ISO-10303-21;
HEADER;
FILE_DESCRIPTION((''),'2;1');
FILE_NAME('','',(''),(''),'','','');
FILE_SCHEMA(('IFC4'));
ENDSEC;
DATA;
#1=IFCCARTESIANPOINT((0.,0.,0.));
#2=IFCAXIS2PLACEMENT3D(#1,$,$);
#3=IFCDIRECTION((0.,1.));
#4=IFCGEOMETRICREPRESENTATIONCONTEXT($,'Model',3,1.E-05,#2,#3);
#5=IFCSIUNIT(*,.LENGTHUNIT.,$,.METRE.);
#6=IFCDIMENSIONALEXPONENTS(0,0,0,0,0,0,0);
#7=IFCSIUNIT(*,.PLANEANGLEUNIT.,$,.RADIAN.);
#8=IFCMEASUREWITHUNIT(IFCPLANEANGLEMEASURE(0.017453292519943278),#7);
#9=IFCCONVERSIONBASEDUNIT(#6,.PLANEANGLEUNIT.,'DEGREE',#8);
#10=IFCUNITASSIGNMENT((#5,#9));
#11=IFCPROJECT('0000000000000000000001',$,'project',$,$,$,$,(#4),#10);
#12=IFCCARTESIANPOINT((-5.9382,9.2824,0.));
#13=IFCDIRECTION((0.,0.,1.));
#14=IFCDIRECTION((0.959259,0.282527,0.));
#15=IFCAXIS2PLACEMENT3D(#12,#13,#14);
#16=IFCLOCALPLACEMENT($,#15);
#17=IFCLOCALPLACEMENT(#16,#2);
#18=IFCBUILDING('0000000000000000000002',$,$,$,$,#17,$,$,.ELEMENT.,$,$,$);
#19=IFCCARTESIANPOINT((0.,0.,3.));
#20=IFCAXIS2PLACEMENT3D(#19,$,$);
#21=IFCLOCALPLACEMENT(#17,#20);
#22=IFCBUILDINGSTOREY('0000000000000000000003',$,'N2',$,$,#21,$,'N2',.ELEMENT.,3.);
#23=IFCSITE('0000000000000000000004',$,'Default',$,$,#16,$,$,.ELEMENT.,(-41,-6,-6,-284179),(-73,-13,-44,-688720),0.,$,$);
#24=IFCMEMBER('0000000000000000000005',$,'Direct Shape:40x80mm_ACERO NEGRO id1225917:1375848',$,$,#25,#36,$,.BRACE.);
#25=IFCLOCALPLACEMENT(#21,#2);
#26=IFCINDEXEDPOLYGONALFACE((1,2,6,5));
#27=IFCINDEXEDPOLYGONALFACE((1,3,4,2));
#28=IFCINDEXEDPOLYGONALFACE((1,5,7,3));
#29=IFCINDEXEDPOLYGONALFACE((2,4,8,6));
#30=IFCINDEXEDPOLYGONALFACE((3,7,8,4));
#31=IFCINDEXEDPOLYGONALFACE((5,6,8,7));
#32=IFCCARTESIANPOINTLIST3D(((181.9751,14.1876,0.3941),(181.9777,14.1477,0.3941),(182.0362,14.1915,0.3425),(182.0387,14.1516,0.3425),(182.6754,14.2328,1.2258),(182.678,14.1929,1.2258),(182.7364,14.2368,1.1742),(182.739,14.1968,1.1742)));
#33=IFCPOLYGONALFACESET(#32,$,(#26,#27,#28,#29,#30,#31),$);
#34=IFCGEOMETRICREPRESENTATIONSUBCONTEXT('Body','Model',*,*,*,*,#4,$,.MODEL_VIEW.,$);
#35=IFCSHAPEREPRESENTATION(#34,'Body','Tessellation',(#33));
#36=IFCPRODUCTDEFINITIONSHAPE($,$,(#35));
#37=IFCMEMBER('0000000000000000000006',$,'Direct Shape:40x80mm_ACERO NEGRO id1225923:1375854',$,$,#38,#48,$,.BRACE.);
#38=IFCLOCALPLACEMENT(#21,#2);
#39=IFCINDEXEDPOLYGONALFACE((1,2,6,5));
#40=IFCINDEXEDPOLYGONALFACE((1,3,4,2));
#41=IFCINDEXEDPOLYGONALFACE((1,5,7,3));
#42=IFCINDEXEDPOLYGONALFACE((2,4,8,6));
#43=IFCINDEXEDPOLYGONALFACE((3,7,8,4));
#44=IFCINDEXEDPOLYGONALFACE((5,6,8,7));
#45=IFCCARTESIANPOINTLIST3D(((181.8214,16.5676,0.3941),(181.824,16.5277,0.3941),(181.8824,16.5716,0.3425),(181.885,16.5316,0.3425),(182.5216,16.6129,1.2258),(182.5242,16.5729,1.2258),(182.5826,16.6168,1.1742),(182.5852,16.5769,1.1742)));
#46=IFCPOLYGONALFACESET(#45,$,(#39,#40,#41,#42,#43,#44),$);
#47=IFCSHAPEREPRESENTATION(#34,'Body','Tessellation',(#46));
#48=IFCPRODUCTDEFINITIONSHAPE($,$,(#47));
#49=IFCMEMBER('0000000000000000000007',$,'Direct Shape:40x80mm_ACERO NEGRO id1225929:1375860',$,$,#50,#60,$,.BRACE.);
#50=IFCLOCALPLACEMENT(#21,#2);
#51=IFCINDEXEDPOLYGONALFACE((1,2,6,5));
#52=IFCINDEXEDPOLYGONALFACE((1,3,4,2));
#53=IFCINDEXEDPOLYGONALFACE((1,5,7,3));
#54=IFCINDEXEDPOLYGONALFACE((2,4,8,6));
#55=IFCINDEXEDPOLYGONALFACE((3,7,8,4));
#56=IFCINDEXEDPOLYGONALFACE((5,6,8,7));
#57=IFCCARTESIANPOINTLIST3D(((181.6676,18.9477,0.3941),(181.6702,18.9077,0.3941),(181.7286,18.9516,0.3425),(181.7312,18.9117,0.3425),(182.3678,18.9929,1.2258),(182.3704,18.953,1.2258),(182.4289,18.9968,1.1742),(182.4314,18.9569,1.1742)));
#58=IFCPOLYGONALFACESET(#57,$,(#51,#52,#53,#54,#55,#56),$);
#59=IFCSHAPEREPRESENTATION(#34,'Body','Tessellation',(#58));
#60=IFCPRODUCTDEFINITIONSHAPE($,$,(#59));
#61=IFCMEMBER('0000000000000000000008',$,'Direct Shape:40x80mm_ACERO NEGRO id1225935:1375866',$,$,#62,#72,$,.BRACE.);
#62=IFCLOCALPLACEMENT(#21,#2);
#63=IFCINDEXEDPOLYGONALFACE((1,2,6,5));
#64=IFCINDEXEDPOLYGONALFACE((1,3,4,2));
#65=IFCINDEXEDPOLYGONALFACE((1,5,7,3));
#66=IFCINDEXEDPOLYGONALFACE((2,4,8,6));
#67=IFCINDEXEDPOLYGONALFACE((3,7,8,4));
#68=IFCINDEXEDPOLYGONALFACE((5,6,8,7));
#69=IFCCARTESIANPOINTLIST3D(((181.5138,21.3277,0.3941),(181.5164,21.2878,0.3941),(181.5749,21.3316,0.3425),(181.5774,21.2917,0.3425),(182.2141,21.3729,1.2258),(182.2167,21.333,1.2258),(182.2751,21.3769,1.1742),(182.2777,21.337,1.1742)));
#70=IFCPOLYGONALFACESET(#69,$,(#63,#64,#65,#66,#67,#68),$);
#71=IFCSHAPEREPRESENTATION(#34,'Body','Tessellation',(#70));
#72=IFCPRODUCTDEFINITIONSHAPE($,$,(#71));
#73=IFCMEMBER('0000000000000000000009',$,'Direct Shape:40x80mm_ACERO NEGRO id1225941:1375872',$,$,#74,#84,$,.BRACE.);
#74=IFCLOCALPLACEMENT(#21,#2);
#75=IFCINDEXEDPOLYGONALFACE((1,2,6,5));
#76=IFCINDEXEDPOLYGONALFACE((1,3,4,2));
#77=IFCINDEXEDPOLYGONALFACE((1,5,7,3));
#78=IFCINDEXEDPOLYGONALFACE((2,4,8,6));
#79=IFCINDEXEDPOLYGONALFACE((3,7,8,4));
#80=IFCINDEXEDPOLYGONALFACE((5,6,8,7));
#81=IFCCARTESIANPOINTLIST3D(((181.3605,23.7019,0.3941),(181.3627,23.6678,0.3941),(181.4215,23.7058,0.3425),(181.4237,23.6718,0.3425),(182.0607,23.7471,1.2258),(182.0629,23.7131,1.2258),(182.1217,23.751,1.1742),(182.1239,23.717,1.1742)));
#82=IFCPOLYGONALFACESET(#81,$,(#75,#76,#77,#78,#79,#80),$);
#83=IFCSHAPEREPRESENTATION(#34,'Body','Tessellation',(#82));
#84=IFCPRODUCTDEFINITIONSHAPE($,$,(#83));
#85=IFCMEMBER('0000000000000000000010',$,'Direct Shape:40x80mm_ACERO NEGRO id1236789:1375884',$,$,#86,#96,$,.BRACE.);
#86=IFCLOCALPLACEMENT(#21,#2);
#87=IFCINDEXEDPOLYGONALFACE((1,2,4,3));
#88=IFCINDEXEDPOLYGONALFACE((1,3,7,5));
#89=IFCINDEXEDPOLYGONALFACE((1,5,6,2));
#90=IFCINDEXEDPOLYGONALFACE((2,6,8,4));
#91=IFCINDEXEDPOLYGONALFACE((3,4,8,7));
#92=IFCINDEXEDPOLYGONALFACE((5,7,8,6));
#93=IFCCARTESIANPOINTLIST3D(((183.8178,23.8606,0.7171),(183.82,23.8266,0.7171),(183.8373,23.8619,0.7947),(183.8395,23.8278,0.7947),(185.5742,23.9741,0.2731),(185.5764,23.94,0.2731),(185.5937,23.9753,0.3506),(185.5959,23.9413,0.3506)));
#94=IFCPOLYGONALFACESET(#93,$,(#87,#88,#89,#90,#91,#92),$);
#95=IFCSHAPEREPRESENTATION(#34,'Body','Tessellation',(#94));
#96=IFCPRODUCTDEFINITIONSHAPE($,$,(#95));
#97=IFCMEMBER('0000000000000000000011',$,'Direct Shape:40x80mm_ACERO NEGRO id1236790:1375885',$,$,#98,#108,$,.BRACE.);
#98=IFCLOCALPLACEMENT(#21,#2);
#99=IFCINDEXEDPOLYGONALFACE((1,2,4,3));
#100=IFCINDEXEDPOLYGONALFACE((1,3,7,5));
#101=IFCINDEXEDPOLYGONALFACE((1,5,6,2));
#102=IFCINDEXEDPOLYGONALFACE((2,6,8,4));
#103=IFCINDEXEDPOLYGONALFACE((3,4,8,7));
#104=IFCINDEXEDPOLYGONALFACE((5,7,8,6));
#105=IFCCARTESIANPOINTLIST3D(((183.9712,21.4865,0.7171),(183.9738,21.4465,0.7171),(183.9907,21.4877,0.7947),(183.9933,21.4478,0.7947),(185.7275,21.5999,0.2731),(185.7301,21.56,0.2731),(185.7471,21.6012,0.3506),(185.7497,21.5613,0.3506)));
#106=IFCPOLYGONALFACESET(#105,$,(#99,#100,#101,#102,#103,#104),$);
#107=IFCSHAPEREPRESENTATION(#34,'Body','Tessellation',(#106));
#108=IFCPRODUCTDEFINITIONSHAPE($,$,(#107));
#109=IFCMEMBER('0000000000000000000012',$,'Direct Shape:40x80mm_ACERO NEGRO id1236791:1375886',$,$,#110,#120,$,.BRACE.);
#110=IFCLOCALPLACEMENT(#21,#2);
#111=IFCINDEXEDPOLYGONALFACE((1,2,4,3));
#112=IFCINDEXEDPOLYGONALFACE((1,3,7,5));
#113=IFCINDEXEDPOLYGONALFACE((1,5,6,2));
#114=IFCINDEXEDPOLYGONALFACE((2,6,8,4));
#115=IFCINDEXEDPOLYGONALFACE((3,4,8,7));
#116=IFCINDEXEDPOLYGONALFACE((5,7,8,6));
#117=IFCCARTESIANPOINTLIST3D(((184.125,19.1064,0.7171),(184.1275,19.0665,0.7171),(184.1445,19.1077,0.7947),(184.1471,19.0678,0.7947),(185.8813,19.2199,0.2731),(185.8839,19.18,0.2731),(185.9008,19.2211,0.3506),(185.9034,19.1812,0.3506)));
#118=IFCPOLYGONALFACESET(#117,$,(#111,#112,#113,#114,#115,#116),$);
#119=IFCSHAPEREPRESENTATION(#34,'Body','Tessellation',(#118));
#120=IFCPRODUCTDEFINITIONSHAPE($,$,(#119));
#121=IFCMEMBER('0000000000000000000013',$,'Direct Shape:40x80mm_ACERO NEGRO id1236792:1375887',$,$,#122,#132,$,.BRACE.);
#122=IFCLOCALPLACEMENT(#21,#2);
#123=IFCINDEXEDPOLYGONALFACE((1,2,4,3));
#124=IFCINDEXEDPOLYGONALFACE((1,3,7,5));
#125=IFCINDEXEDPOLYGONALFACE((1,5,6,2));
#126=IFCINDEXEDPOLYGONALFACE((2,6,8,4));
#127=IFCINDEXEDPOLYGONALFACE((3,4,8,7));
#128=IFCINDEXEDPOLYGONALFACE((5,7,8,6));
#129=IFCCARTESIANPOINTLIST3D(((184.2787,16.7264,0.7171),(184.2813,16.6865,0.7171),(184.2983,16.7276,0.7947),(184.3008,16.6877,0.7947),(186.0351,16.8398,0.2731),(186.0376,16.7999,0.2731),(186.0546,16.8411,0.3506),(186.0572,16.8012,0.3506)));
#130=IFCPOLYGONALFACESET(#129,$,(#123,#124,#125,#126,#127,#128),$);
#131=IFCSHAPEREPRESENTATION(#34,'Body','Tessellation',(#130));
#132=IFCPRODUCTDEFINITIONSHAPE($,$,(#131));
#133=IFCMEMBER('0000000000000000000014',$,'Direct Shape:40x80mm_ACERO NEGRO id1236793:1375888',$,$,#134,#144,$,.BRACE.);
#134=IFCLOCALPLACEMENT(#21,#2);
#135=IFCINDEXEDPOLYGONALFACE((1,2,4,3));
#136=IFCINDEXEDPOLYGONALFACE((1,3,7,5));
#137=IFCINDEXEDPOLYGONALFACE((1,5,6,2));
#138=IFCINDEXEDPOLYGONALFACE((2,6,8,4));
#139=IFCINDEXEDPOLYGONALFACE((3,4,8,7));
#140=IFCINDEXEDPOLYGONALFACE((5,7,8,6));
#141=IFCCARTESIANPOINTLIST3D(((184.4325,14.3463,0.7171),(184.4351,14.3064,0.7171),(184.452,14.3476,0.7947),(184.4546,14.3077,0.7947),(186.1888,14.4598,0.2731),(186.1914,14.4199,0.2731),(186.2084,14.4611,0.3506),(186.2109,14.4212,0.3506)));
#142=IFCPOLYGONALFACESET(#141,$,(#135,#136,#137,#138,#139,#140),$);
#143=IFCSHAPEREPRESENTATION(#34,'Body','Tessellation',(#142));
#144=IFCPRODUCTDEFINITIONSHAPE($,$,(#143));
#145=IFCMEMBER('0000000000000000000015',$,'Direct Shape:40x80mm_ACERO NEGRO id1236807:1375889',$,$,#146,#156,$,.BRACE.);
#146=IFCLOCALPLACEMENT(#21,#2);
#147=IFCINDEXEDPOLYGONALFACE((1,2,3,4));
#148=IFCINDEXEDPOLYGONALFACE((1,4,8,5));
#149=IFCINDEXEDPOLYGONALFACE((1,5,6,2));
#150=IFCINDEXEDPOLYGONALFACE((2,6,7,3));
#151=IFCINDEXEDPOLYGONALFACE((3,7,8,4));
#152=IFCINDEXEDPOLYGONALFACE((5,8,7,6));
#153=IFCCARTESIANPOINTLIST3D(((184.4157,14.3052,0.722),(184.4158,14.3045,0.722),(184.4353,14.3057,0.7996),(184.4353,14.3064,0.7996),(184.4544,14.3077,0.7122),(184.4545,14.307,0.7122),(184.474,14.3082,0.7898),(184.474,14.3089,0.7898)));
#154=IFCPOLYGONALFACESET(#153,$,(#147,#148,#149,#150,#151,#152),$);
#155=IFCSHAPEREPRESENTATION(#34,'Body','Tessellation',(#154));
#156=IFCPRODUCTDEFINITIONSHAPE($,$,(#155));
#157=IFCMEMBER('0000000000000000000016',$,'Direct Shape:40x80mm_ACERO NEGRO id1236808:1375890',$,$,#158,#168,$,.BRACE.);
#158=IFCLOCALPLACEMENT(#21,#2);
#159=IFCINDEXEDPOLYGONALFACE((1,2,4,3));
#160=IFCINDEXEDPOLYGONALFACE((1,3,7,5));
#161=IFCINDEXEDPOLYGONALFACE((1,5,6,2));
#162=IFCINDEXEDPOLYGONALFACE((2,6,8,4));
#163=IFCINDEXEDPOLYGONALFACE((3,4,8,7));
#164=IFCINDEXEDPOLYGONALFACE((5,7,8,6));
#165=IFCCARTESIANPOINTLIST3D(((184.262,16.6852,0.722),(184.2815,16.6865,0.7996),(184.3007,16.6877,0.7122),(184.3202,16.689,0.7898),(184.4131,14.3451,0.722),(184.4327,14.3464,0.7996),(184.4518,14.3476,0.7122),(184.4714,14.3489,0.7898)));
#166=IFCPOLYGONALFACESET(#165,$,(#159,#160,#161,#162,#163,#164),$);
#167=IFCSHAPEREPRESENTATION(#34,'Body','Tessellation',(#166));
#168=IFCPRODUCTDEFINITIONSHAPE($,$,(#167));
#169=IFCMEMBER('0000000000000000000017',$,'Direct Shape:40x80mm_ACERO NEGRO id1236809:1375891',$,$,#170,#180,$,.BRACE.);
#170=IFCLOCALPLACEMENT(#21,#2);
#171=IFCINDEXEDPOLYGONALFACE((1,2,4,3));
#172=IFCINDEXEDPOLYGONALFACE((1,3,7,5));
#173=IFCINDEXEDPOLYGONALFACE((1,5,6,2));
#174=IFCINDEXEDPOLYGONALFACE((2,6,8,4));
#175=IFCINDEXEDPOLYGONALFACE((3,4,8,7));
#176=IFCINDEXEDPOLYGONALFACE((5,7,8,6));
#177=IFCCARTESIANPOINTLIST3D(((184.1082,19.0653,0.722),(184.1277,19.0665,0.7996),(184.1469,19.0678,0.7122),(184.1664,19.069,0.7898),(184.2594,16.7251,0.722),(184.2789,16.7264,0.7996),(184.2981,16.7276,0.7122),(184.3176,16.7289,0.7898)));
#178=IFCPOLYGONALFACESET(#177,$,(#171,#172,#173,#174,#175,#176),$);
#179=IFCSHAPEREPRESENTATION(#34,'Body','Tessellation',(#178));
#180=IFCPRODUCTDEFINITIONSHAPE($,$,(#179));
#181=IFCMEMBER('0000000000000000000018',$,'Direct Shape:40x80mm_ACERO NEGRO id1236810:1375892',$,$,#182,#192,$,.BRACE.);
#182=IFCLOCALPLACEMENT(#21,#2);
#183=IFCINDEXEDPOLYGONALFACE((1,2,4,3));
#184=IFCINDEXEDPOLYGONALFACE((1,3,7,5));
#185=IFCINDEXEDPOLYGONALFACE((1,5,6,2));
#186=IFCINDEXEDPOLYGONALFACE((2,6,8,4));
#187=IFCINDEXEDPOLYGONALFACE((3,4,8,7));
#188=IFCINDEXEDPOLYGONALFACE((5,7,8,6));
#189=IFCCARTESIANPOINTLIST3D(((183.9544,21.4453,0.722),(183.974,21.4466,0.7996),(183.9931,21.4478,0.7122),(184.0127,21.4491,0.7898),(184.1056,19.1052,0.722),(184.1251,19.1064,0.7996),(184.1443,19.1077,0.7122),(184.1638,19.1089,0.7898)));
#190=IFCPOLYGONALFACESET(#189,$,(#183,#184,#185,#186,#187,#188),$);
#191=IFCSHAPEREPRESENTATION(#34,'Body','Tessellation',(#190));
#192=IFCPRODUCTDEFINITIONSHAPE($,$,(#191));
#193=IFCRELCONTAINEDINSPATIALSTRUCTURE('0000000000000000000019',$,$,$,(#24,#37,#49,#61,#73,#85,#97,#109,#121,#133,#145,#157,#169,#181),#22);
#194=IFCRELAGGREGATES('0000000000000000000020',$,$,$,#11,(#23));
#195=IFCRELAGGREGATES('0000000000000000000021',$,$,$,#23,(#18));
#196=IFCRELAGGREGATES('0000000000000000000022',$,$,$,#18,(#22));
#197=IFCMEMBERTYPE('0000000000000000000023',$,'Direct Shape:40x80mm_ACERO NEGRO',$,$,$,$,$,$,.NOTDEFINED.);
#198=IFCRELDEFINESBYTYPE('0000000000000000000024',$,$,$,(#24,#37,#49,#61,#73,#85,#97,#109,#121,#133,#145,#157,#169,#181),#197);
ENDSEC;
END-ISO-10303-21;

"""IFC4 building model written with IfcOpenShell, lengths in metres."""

from ifc_helpers import new_model, entity, si_unit, converted_unit, direction, frame, frame_2d, origin, place, context, subcontext, project, spatial, rectangle, extrude, type_object, element, save


model = new_model("IFC4")

# Units and contexts
model_context = context("Model", 3, precision=1e-05, world=origin(), true_north=direction((0.0, 1.0)))
body_context = subcontext(model_context, "Body", "Model", "MODEL_VIEW")
ifc_project = project(units=[si_unit("LENGTHUNIT", "METRE"), converted_unit("PLANEANGLEUNIT", "DEGREE", entity("IfcPlaneAngleMeasure", 0.017453292519943278), si_unit("PLANEANGLEUNIT", "RADIAN"), dimensions=[0, 0, 0, 0, 0, 0, 0])], contexts=[model_context])

# Site, building, storey
site_placement = place(None, frame((-5.9382, 9.2824, 0.0), z_axis=(0.0, 0.0, 1.0), x_axis=(0.959259, 0.282527, 0.0)))
site = spatial("IfcSite", under=ifc_project, at=site_placement, Name="Default", CompositionType="ELEMENT", RefLatitude=(-41, -6, -6, -284179), RefLongitude=(-73, -13, -44, -688720), RefElevation=0.0)
building_placement = place(site_placement, origin())
building = spatial("IfcBuilding", under=site, at=building_placement, CompositionType="ELEMENT")
storey_placement = place(building_placement, frame((0.0, 0.0, 3.0)))
storey = spatial("IfcBuildingStorey", under=building, at=storey_placement, Name="N2", LongName="N2", CompositionType="ELEMENT", Elevation=3.0)

# Members
member_type_1 = type_object("IfcMemberType", Name="Direct Shape:40x80mm_ACERO NEGRO", PredefinedType="NOTDEFINED")
member_1_placement = place(storey_placement, origin())
element("IfcMember", 1, at=member_1_placement, inside=storey, type_object=member_type_1, Name="Direct Shape:40x80mm_ACERO NEGRO id1225917:1375848", PredefinedType="BRACE", context=body_context, shape_type="SweptSolid", body=[
    extrude(rectangle(XDim=0.08, YDim=0.04, at=frame_2d((0.0, 0.0), x_axis=(0.0, 1.0))), frame((182.0069, 14.1696, 0.3683), z_axis=(0.643515, 0.041575, 0.764304), x_axis=(0.064471, -0.99792, 0.0)), (0.0, 0.0, 1.0), 1.0881),
])
member_2_placement = place(storey_placement, origin())
element("IfcMember", 2, at=member_2_placement, inside=storey, type_object=member_type_1, Name="Direct Shape:40x80mm_ACERO NEGRO id1225923:1375854", PredefinedType="BRACE", context=body_context, shape_type="SweptSolid", body=[
    extrude(rectangle(XDim=0.08, YDim=0.04, at=frame_2d((0.0, 0.0), x_axis=(0.0, 1.0))), frame((181.8532, 16.5496, 0.3683), z_axis=(0.643515, 0.041575, 0.764304), x_axis=(0.064471, -0.99792, 0.0)), (0.0, 0.0, 1.0), 1.0881),
])
member_3_placement = place(storey_placement, origin())
element("IfcMember", 3, at=member_3_placement, inside=storey, type_object=member_type_1, Name="Direct Shape:40x80mm_ACERO NEGRO id1225929:1375860", PredefinedType="BRACE", context=body_context, shape_type="SweptSolid", body=[
    extrude(rectangle(XDim=0.08, YDim=0.04, at=frame_2d((0.0, 0.0), x_axis=(0.0, 1.0))), frame((181.6994, 18.9297, 0.3683), z_axis=(0.643515, 0.041575, 0.764304), x_axis=(0.064471, -0.99792, 0.0)), (0.0, 0.0, 1.0), 1.0881),
])
member_4_placement = place(storey_placement, origin())
element("IfcMember", 4, at=member_4_placement, inside=storey, type_object=member_type_1, Name="Direct Shape:40x80mm_ACERO NEGRO id1225935:1375866", PredefinedType="BRACE", context=body_context, shape_type="SweptSolid", body=[
    extrude(rectangle(XDim=0.08, YDim=0.04, at=frame_2d((0.0, 0.0), x_axis=(0.0, 1.0))), frame((181.5456, 21.3097, 0.3683), z_axis=(0.643515, 0.041575, 0.764304), x_axis=(0.064471, -0.99792, 0.0)), (0.0, 0.0, 1.0), 1.0881),
])
member_5_placement = place(storey_placement, origin())
element("IfcMember", 5, at=member_5_placement, inside=storey, type_object=member_type_1, Name="Direct Shape:40x80mm_ACERO NEGRO id1225941:1375872", PredefinedType="BRACE", context=body_context, shape_type="SweptSolid", body=[
    extrude(rectangle(XDim=0.08, YDim=0.0341, at=frame_2d((0.0, 0.0), x_axis=(0.0, 1.0))), frame((181.3921, 23.6868, 0.3683), z_axis=(0.643515, 0.041575, 0.764304), x_axis=(0.064471, -0.99792, 0.0)), (0.0, 0.0, 1.0), 1.0881),
])
member_6_placement = place(storey_placement, origin())
element("IfcMember", 6, at=member_6_placement, inside=storey, type_object=member_type_1, Name="Direct Shape:40x80mm_ACERO NEGRO id1236789:1375884", PredefinedType="BRACE", context=body_context, shape_type="SweptSolid", body=[
    extrude(rectangle(XDim=0.08, YDim=0.0341, at=frame_2d((0.0, 0.0), x_axis=(0.0, 1.0))), frame((183.8287, 23.8442, 0.7559), z_axis=(0.967595, 0.062512, -0.244649), x_axis=(0.064471, -0.99792, 0.0)), (0.0, 0.0, 1.0), 1.8152),
])
member_7_placement = place(storey_placement, origin())
element("IfcMember", 7, at=member_7_placement, inside=storey, type_object=member_type_1, Name="Direct Shape:40x80mm_ACERO NEGRO id1236790:1375885", PredefinedType="BRACE", context=body_context, shape_type="SweptSolid", body=[
    extrude(rectangle(XDim=0.08, YDim=0.04, at=frame_2d((0.0, 0.0), x_axis=(1.0, 0.0))), frame((183.9823, 21.4671, 0.7559), z_axis=(0.967595, 0.062512, -0.244649), x_axis=(-0.24414, -0.015773, -0.969612)), (0.0, 0.0, 1.0), 1.8152),
])
member_8_placement = place(storey_placement, origin())
element("IfcMember", 8, at=member_8_placement, inside=storey, type_object=member_type_1, Name="Direct Shape:40x80mm_ACERO NEGRO id1236791:1375886", PredefinedType="BRACE", context=body_context, shape_type="SweptSolid", body=[
    extrude(rectangle(XDim=0.08, YDim=0.04, at=frame_2d((0.0, 0.0), x_axis=(1.0, 0.0))), frame((184.136, 19.0871, 0.7559), z_axis=(0.967595, 0.062512, -0.244649), x_axis=(-0.24414, -0.015773, -0.969612)), (0.0, 0.0, 1.0), 1.8152),
])
member_9_placement = place(storey_placement, origin())
element("IfcMember", 9, at=member_9_placement, inside=storey, type_object=member_type_1, Name="Direct Shape:40x80mm_ACERO NEGRO id1236792:1375887", PredefinedType="BRACE", context=body_context, shape_type="SweptSolid", body=[
    extrude(rectangle(XDim=0.08, YDim=0.04, at=frame_2d((0.0, 0.0), x_axis=(1.0, 0.0))), frame((184.2898, 16.7071, 0.7559), z_axis=(0.967595, 0.062512, -0.244649), x_axis=(-0.24414, -0.015773, -0.969612)), (0.0, 0.0, 1.0), 1.8152),
])
member_10_placement = place(storey_placement, origin())
element("IfcMember", 10, at=member_10_placement, inside=storey, type_object=member_type_1, Name="Direct Shape:40x80mm_ACERO NEGRO id1236793:1375888", PredefinedType="BRACE", context=body_context, shape_type="SweptSolid", body=[
    extrude(rectangle(XDim=0.08, YDim=0.04, at=frame_2d((0.0, 0.0), x_axis=(1.0, 0.0))), frame((184.4435, 14.327, 0.7559), z_axis=(0.967595, 0.062512, -0.244649), x_axis=(-0.24414, -0.015773, -0.969612)), (0.0, 0.0, 1.0), 1.8152),
])
member_11_placement = place(storey_placement, origin())
element("IfcMember", 11, at=member_11_placement, inside=storey, type_object=member_type_1, Name="Direct Shape:40x80mm_ACERO NEGRO id1236807:1375889", PredefinedType="BRACE", context=body_context, shape_type="SweptSolid", body=[
    extrude(rectangle(XDim=0.04, YDim=0.0007, at=frame_2d((0.0, 0.0), x_axis=(0.0, 1.0))), frame((184.4351, 14.3061, 0.7171), z_axis=(0.24414, 0.015773, 0.969612), x_axis=(-0.064471, 0.99792, 0.0)), (0.0, 0.0, 1.0), 0.08),
])
member_12_placement = place(storey_placement, origin())
element("IfcMember", 12, at=member_12_placement, inside=storey, type_object=member_type_1, Name="Direct Shape:40x80mm_ACERO NEGRO id1236808:1375890", PredefinedType="BRACE", context=body_context, shape_type="SweptSolid", body=[
    extrude(rectangle(XDim=0.08, YDim=0.04, at=frame_2d((0.0, 0.0), x_axis=(0.0, 1.0))), frame((184.4423, 14.347, 0.7559), z_axis=(-0.064471, 0.99792, 0.0), x_axis=(0.967595, 0.062512, -0.244649)), (0.0, 0.0, 1.0), 2.345),
])
member_13_placement = place(storey_placement, origin())
element("IfcMember", 13, at=member_13_placement, inside=storey, type_object=member_type_1, Name="Direct Shape:40x80mm_ACERO NEGRO id1236809:1375891", PredefinedType="BRACE", context=body_context, shape_type="SweptSolid", body=[
    extrude(rectangle(XDim=0.08, YDim=0.04, at=frame_2d((0.0, 0.0), x_axis=(0.0, 1.0))), frame((184.2885, 16.727, 0.7559), z_axis=(-0.064471, 0.99792, 0.0), x_axis=(0.967595, 0.062512, -0.244649)), (0.0, 0.0, 1.0), 2.345),
])
member_14_placement = place(storey_placement, origin())
element("IfcMember", 14, at=member_14_placement, inside=storey, type_object=member_type_1, Name="Direct Shape:40x80mm_ACERO NEGRO id1236810:1375892", PredefinedType="BRACE", context=body_context, shape_type="SweptSolid", body=[
    extrude(rectangle(XDim=0.08, YDim=0.04, at=frame_2d((0.0, 0.0), x_axis=(0.0, 1.0))), frame((184.1347, 19.107, 0.7559), z_axis=(-0.064471, 0.99792, 0.0), x_axis=(0.967595, 0.062512, -0.244649)), (0.0, 0.0, 1.0), 2.345),
])

save(model, "model.ifc")
